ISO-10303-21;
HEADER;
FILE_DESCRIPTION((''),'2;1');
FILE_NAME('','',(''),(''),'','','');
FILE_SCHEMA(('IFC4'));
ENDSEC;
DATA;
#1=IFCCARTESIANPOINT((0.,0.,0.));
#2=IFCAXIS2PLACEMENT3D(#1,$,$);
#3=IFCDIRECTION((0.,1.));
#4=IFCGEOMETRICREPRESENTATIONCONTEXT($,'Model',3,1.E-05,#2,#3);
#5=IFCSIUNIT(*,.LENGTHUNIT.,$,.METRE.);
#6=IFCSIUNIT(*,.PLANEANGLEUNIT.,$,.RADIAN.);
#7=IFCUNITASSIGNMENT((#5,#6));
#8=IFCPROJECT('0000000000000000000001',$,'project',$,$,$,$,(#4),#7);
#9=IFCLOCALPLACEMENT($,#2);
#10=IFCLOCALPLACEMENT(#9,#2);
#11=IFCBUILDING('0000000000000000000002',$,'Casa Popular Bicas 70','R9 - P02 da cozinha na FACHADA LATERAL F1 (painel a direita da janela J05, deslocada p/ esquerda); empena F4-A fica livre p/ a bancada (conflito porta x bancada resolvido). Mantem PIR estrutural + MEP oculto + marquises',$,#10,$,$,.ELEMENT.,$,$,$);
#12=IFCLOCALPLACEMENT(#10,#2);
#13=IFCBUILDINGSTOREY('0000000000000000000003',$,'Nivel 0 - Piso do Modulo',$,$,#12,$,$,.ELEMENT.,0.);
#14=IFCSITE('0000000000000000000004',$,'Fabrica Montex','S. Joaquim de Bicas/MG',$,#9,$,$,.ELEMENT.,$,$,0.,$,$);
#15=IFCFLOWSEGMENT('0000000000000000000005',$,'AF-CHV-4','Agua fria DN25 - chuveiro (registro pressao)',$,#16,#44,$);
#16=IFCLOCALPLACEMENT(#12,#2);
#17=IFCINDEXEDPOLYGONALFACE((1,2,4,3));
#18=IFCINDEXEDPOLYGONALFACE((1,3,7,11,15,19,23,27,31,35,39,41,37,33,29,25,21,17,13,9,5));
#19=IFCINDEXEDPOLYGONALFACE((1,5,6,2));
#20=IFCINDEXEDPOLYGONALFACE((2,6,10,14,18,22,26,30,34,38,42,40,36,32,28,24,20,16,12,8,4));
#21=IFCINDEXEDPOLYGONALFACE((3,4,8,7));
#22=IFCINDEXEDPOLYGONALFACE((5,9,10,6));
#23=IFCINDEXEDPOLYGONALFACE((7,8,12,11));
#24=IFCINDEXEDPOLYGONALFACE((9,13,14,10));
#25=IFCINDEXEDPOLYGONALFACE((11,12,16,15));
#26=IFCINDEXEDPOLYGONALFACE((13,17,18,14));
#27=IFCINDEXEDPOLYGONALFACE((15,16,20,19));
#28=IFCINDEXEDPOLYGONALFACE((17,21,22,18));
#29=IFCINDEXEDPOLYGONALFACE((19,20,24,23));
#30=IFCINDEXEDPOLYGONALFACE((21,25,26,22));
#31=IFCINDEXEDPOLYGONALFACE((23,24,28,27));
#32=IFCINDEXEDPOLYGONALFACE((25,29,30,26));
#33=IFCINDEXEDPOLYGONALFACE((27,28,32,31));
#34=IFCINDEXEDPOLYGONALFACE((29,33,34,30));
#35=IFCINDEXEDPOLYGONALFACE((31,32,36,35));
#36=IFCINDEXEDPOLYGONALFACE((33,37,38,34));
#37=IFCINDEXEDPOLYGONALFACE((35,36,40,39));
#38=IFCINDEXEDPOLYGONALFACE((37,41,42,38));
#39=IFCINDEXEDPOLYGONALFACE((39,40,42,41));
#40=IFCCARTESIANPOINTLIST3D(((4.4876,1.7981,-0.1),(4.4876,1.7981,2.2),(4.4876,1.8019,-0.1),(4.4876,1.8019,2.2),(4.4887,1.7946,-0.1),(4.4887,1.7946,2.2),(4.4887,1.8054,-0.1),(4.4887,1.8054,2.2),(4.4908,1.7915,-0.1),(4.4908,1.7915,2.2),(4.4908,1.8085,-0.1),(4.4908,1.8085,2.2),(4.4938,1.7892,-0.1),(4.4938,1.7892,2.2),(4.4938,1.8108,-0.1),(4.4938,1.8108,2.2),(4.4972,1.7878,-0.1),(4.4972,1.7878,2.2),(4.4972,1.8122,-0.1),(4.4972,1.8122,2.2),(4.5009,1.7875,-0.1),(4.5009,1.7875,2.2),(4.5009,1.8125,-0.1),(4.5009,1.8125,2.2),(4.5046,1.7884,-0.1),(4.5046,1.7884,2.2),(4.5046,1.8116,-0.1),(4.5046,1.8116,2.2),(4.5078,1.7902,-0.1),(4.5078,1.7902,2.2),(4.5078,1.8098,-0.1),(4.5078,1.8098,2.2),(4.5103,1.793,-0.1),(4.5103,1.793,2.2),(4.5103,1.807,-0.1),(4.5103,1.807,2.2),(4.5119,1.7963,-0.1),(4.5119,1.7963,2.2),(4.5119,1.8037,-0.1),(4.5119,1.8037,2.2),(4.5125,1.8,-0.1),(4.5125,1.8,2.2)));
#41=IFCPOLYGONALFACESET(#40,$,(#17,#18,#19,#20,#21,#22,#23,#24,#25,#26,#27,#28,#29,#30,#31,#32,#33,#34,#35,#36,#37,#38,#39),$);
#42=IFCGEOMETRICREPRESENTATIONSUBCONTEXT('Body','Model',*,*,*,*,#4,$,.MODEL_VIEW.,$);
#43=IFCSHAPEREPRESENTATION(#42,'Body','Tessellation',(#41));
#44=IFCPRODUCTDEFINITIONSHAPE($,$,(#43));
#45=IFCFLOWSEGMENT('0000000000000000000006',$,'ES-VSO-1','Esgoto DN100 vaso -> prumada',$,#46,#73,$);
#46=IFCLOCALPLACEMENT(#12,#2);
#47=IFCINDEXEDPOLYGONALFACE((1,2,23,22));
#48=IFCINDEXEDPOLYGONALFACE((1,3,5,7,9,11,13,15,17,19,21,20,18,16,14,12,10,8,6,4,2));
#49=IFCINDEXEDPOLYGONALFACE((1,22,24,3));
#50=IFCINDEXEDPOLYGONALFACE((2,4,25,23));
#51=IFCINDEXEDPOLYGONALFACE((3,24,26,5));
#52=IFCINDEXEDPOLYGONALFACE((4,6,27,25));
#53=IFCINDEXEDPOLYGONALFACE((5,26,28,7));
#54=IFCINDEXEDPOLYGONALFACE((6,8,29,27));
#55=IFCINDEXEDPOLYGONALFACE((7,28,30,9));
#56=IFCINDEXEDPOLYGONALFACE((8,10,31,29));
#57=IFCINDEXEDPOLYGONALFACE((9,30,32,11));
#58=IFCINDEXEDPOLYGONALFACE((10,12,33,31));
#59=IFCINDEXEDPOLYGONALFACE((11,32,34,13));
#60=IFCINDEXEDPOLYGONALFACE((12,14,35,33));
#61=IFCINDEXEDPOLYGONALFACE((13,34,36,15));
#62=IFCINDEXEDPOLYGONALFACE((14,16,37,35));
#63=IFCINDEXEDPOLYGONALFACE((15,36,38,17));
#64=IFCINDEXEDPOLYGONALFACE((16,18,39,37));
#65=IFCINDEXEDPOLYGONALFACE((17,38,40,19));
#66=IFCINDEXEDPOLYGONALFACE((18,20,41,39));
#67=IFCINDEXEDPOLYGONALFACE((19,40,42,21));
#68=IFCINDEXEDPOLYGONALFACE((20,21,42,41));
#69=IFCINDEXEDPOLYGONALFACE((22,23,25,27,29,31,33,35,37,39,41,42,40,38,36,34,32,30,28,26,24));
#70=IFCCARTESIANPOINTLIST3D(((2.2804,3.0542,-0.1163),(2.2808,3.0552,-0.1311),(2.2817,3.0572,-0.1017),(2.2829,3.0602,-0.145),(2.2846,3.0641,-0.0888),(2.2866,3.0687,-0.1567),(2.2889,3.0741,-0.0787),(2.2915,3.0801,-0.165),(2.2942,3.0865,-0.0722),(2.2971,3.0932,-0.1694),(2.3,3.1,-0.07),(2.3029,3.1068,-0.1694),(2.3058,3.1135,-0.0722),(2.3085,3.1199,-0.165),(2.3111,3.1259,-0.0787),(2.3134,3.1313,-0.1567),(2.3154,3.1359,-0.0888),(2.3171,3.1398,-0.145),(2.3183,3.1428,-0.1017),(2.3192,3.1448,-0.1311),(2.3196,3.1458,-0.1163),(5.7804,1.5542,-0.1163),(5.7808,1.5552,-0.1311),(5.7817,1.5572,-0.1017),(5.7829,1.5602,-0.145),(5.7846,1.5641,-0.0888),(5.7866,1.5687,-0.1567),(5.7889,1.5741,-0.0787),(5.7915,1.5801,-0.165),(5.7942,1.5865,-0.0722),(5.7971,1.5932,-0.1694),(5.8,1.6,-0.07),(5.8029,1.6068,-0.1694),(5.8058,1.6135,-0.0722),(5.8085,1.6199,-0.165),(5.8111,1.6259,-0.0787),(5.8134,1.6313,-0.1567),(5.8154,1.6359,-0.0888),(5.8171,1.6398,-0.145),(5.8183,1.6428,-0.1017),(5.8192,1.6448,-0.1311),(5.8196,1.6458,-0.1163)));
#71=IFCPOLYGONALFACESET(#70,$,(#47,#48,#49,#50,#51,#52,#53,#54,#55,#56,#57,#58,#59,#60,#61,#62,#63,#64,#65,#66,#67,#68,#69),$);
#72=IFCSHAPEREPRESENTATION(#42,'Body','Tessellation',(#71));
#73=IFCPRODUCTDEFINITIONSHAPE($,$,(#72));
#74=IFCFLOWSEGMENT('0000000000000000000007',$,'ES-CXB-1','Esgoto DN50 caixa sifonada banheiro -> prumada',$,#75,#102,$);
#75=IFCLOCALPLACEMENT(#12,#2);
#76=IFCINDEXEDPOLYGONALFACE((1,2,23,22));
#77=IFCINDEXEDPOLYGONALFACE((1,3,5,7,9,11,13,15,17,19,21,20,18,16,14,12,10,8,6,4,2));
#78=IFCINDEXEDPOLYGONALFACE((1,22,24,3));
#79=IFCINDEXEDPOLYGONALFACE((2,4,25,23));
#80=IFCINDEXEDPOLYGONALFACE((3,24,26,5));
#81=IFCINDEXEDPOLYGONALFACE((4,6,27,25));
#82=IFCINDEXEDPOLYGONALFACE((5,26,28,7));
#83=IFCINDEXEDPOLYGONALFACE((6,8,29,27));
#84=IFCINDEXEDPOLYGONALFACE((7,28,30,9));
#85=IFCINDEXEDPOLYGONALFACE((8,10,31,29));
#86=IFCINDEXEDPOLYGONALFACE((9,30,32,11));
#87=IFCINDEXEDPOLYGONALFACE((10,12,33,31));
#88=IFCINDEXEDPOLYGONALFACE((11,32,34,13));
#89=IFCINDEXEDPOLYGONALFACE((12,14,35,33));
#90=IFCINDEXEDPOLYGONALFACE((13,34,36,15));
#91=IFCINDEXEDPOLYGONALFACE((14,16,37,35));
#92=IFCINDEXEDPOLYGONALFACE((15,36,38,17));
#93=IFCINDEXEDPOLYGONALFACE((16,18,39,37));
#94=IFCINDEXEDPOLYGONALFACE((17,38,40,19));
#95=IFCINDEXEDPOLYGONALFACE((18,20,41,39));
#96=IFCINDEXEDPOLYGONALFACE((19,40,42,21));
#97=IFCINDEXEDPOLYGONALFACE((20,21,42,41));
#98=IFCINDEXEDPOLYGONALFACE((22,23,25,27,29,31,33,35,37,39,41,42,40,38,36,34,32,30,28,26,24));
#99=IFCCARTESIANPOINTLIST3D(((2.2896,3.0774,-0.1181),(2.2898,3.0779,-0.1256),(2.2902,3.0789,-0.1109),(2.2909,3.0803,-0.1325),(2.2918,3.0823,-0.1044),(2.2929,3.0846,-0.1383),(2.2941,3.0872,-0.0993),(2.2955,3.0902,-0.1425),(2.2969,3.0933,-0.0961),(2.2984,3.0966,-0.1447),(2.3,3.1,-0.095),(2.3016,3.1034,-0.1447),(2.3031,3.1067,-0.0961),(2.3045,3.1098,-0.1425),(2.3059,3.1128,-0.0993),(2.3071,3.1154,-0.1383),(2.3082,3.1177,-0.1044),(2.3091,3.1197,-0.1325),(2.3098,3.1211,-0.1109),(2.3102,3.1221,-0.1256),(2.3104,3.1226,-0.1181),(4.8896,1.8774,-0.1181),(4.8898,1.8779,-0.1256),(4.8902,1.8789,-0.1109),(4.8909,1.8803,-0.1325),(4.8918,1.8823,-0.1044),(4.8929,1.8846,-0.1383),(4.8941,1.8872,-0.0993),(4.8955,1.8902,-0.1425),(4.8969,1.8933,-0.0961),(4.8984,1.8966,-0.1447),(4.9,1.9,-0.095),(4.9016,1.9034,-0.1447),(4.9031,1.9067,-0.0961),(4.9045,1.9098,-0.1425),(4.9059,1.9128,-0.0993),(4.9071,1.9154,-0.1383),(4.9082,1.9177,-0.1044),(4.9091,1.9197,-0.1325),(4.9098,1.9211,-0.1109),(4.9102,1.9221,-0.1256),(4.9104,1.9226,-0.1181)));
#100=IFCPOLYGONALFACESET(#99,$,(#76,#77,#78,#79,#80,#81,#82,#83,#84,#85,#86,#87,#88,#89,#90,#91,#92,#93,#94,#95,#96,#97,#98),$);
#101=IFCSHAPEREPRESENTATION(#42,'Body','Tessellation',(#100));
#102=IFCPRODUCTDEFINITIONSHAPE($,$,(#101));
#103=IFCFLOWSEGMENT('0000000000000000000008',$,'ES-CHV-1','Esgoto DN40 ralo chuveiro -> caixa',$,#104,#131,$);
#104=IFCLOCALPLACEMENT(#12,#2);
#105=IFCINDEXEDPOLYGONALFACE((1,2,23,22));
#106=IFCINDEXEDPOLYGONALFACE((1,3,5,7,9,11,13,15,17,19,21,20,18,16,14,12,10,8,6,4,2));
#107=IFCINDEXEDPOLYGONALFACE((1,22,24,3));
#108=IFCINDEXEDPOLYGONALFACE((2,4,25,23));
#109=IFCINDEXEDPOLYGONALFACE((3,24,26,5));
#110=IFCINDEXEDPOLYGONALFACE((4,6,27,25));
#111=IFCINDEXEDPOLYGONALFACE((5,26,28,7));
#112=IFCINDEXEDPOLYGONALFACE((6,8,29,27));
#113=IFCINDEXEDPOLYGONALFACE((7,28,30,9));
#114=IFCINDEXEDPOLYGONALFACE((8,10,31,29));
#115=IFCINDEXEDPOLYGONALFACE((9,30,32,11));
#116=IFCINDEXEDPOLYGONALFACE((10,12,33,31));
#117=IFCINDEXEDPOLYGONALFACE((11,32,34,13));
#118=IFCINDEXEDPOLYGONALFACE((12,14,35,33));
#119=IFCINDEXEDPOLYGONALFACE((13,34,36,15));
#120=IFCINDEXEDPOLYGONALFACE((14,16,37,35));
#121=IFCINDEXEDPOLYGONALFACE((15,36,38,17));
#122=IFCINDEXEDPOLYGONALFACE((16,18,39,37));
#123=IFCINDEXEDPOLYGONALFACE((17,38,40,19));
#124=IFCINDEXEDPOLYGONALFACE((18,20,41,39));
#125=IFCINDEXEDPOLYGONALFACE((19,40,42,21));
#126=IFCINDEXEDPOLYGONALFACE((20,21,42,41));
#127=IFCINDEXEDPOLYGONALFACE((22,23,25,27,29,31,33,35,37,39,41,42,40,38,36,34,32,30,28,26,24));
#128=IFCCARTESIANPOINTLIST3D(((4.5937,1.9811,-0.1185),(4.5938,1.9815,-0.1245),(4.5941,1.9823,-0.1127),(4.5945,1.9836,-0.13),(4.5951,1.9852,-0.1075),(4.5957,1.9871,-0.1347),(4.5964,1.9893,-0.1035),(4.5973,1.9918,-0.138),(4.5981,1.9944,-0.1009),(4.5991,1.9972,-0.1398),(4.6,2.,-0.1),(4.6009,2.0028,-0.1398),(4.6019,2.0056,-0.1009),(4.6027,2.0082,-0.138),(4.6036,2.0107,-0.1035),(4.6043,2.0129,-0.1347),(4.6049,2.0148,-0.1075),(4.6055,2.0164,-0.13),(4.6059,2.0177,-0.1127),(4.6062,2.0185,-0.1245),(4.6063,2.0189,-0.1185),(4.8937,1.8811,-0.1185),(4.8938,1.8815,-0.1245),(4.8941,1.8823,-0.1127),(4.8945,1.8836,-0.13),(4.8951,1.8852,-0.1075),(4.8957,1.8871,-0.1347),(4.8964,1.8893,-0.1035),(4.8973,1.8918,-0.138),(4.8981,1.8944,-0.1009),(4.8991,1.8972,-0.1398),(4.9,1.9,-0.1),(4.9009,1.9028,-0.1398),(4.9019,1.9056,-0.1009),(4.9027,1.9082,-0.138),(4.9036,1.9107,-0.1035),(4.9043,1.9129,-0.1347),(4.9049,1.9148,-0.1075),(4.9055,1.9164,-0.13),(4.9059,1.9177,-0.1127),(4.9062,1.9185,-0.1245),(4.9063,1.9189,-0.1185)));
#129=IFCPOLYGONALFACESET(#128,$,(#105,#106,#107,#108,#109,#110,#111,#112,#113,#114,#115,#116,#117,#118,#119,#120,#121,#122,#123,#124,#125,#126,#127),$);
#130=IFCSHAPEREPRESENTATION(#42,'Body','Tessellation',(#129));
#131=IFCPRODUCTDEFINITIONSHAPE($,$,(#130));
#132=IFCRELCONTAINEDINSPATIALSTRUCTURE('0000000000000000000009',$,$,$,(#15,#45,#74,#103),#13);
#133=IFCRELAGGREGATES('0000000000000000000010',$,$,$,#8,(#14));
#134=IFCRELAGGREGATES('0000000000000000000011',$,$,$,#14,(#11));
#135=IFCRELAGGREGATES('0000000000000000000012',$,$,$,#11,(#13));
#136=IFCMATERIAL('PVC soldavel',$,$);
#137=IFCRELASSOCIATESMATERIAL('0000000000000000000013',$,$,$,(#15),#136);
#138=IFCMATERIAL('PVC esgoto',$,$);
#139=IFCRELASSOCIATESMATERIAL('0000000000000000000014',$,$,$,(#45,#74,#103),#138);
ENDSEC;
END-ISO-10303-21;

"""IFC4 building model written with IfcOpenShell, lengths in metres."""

from ifc_helpers import new_model, si_unit, direction, frame, origin, origin_2d, place, context, subcontext, project, spatial, circle, extrude, material, element, save


model = new_model("IFC4")

# Units and contexts
model_context = context("Model", 3, precision=1e-05, world=origin(), true_north=direction((0.0, 1.0)))
body_context = subcontext(model_context, "Body", "Model", "MODEL_VIEW")
ifc_project = project(units=[si_unit("LENGTHUNIT", "METRE"), si_unit("PLANEANGLEUNIT", "RADIAN")], contexts=[model_context])

# Site, building, storey
site_placement = place(None, origin())
site = spatial("IfcSite", under=ifc_project, at=site_placement, Name="Fabrica Montex", Description="S. Joaquim de Bicas/MG", CompositionType="ELEMENT", RefElevation=0.0)
building_placement = place(site_placement, origin())
building = spatial("IfcBuilding", under=site, at=building_placement, Name="Casa Popular Bicas 70", Description="R9 - P02 da cozinha na FACHADA LATERAL F1 (painel a direita da janela J05, deslocada p/ esquerda); empena F4-A fica livre p/ a bancada (conflito porta x bancada resolvido). Mantem PIR estrutural + MEP oculto + marquises", CompositionType="ELEMENT")
storey_placement = place(building_placement, origin())
storey = spatial("IfcBuildingStorey", under=building, at=storey_placement, Name="Nivel 0 - Piso do Modulo", CompositionType="ELEMENT", Elevation=0.0)

# Flow segments
ifc_material_1 = material(Name="PVC soldavel")
flow_segment_1_placement = place(storey_placement, frame((4.5, 1.8, -0.1), z_axis=(0.0, 0.0, 1.0), x_axis=(1.0, 0.0, 0.0)))
element("IfcFlowSegment", 1, at=flow_segment_1_placement, inside=storey, material=ifc_material_1, Name="AF-CHV-4", Description="Agua fria DN25 - chuveiro (registro pressao)", context=body_context, shape_type="SweptSolid", body=[
    extrude(circle(Radius=0.0125, at=origin_2d()), origin(), (0.0, 0.0, 1.0), 2.3),
])
ifc_material_2 = material(Name="PVC esgoto")
flow_segment_2_placement = place(storey_placement, frame((5.8, 1.6, -0.12), z_axis=(-0.919145, 0.393919, 0.0), x_axis=(0.0, 0.0, 1.0)))
element("IfcFlowSegment", 2, at=flow_segment_2_placement, inside=storey, material=ifc_material_2, Name="ES-VSO-1", Description="Esgoto DN100 vaso -> prumada", context=body_context, shape_type="SweptSolid", body=[
    extrude(circle(Radius=0.05, at=origin_2d()), origin(), (0.0, 0.0, 1.0), 3.8079),
])
flow_segment_3_placement = place(storey_placement, frame((4.9, 1.9, -0.12), z_axis=(-0.907959, 0.419058, 0.0), x_axis=(0.0, 0.0, 1.0)))
element("IfcFlowSegment", 3, at=flow_segment_3_placement, inside=storey, material=ifc_material_2, Name="ES-CXB-1", Description="Esgoto DN50 caixa sifonada banheiro -> prumada", context=body_context, shape_type="SweptSolid", body=[
    extrude(circle(Radius=0.025, at=origin_2d()), origin(), (0.0, 0.0, 1.0), 2.8636),
])
flow_segment_4_placement = place(storey_placement, frame((4.6, 2.0, -0.12), z_axis=(0.948683, -0.316228, 0.0), x_axis=(0.0, 0.0, 1.0)))
element("IfcFlowSegment", 4, at=flow_segment_4_placement, inside=storey, material=ifc_material_2, Name="ES-CHV-1", Description="Esgoto DN40 ralo chuveiro -> caixa", context=body_context, shape_type="SweptSolid", body=[
    extrude(circle(Radius=0.02, at=origin_2d()), origin(), (0.0, 0.0, 1.0), 0.3162),
])

save(model, "model.ifc")
